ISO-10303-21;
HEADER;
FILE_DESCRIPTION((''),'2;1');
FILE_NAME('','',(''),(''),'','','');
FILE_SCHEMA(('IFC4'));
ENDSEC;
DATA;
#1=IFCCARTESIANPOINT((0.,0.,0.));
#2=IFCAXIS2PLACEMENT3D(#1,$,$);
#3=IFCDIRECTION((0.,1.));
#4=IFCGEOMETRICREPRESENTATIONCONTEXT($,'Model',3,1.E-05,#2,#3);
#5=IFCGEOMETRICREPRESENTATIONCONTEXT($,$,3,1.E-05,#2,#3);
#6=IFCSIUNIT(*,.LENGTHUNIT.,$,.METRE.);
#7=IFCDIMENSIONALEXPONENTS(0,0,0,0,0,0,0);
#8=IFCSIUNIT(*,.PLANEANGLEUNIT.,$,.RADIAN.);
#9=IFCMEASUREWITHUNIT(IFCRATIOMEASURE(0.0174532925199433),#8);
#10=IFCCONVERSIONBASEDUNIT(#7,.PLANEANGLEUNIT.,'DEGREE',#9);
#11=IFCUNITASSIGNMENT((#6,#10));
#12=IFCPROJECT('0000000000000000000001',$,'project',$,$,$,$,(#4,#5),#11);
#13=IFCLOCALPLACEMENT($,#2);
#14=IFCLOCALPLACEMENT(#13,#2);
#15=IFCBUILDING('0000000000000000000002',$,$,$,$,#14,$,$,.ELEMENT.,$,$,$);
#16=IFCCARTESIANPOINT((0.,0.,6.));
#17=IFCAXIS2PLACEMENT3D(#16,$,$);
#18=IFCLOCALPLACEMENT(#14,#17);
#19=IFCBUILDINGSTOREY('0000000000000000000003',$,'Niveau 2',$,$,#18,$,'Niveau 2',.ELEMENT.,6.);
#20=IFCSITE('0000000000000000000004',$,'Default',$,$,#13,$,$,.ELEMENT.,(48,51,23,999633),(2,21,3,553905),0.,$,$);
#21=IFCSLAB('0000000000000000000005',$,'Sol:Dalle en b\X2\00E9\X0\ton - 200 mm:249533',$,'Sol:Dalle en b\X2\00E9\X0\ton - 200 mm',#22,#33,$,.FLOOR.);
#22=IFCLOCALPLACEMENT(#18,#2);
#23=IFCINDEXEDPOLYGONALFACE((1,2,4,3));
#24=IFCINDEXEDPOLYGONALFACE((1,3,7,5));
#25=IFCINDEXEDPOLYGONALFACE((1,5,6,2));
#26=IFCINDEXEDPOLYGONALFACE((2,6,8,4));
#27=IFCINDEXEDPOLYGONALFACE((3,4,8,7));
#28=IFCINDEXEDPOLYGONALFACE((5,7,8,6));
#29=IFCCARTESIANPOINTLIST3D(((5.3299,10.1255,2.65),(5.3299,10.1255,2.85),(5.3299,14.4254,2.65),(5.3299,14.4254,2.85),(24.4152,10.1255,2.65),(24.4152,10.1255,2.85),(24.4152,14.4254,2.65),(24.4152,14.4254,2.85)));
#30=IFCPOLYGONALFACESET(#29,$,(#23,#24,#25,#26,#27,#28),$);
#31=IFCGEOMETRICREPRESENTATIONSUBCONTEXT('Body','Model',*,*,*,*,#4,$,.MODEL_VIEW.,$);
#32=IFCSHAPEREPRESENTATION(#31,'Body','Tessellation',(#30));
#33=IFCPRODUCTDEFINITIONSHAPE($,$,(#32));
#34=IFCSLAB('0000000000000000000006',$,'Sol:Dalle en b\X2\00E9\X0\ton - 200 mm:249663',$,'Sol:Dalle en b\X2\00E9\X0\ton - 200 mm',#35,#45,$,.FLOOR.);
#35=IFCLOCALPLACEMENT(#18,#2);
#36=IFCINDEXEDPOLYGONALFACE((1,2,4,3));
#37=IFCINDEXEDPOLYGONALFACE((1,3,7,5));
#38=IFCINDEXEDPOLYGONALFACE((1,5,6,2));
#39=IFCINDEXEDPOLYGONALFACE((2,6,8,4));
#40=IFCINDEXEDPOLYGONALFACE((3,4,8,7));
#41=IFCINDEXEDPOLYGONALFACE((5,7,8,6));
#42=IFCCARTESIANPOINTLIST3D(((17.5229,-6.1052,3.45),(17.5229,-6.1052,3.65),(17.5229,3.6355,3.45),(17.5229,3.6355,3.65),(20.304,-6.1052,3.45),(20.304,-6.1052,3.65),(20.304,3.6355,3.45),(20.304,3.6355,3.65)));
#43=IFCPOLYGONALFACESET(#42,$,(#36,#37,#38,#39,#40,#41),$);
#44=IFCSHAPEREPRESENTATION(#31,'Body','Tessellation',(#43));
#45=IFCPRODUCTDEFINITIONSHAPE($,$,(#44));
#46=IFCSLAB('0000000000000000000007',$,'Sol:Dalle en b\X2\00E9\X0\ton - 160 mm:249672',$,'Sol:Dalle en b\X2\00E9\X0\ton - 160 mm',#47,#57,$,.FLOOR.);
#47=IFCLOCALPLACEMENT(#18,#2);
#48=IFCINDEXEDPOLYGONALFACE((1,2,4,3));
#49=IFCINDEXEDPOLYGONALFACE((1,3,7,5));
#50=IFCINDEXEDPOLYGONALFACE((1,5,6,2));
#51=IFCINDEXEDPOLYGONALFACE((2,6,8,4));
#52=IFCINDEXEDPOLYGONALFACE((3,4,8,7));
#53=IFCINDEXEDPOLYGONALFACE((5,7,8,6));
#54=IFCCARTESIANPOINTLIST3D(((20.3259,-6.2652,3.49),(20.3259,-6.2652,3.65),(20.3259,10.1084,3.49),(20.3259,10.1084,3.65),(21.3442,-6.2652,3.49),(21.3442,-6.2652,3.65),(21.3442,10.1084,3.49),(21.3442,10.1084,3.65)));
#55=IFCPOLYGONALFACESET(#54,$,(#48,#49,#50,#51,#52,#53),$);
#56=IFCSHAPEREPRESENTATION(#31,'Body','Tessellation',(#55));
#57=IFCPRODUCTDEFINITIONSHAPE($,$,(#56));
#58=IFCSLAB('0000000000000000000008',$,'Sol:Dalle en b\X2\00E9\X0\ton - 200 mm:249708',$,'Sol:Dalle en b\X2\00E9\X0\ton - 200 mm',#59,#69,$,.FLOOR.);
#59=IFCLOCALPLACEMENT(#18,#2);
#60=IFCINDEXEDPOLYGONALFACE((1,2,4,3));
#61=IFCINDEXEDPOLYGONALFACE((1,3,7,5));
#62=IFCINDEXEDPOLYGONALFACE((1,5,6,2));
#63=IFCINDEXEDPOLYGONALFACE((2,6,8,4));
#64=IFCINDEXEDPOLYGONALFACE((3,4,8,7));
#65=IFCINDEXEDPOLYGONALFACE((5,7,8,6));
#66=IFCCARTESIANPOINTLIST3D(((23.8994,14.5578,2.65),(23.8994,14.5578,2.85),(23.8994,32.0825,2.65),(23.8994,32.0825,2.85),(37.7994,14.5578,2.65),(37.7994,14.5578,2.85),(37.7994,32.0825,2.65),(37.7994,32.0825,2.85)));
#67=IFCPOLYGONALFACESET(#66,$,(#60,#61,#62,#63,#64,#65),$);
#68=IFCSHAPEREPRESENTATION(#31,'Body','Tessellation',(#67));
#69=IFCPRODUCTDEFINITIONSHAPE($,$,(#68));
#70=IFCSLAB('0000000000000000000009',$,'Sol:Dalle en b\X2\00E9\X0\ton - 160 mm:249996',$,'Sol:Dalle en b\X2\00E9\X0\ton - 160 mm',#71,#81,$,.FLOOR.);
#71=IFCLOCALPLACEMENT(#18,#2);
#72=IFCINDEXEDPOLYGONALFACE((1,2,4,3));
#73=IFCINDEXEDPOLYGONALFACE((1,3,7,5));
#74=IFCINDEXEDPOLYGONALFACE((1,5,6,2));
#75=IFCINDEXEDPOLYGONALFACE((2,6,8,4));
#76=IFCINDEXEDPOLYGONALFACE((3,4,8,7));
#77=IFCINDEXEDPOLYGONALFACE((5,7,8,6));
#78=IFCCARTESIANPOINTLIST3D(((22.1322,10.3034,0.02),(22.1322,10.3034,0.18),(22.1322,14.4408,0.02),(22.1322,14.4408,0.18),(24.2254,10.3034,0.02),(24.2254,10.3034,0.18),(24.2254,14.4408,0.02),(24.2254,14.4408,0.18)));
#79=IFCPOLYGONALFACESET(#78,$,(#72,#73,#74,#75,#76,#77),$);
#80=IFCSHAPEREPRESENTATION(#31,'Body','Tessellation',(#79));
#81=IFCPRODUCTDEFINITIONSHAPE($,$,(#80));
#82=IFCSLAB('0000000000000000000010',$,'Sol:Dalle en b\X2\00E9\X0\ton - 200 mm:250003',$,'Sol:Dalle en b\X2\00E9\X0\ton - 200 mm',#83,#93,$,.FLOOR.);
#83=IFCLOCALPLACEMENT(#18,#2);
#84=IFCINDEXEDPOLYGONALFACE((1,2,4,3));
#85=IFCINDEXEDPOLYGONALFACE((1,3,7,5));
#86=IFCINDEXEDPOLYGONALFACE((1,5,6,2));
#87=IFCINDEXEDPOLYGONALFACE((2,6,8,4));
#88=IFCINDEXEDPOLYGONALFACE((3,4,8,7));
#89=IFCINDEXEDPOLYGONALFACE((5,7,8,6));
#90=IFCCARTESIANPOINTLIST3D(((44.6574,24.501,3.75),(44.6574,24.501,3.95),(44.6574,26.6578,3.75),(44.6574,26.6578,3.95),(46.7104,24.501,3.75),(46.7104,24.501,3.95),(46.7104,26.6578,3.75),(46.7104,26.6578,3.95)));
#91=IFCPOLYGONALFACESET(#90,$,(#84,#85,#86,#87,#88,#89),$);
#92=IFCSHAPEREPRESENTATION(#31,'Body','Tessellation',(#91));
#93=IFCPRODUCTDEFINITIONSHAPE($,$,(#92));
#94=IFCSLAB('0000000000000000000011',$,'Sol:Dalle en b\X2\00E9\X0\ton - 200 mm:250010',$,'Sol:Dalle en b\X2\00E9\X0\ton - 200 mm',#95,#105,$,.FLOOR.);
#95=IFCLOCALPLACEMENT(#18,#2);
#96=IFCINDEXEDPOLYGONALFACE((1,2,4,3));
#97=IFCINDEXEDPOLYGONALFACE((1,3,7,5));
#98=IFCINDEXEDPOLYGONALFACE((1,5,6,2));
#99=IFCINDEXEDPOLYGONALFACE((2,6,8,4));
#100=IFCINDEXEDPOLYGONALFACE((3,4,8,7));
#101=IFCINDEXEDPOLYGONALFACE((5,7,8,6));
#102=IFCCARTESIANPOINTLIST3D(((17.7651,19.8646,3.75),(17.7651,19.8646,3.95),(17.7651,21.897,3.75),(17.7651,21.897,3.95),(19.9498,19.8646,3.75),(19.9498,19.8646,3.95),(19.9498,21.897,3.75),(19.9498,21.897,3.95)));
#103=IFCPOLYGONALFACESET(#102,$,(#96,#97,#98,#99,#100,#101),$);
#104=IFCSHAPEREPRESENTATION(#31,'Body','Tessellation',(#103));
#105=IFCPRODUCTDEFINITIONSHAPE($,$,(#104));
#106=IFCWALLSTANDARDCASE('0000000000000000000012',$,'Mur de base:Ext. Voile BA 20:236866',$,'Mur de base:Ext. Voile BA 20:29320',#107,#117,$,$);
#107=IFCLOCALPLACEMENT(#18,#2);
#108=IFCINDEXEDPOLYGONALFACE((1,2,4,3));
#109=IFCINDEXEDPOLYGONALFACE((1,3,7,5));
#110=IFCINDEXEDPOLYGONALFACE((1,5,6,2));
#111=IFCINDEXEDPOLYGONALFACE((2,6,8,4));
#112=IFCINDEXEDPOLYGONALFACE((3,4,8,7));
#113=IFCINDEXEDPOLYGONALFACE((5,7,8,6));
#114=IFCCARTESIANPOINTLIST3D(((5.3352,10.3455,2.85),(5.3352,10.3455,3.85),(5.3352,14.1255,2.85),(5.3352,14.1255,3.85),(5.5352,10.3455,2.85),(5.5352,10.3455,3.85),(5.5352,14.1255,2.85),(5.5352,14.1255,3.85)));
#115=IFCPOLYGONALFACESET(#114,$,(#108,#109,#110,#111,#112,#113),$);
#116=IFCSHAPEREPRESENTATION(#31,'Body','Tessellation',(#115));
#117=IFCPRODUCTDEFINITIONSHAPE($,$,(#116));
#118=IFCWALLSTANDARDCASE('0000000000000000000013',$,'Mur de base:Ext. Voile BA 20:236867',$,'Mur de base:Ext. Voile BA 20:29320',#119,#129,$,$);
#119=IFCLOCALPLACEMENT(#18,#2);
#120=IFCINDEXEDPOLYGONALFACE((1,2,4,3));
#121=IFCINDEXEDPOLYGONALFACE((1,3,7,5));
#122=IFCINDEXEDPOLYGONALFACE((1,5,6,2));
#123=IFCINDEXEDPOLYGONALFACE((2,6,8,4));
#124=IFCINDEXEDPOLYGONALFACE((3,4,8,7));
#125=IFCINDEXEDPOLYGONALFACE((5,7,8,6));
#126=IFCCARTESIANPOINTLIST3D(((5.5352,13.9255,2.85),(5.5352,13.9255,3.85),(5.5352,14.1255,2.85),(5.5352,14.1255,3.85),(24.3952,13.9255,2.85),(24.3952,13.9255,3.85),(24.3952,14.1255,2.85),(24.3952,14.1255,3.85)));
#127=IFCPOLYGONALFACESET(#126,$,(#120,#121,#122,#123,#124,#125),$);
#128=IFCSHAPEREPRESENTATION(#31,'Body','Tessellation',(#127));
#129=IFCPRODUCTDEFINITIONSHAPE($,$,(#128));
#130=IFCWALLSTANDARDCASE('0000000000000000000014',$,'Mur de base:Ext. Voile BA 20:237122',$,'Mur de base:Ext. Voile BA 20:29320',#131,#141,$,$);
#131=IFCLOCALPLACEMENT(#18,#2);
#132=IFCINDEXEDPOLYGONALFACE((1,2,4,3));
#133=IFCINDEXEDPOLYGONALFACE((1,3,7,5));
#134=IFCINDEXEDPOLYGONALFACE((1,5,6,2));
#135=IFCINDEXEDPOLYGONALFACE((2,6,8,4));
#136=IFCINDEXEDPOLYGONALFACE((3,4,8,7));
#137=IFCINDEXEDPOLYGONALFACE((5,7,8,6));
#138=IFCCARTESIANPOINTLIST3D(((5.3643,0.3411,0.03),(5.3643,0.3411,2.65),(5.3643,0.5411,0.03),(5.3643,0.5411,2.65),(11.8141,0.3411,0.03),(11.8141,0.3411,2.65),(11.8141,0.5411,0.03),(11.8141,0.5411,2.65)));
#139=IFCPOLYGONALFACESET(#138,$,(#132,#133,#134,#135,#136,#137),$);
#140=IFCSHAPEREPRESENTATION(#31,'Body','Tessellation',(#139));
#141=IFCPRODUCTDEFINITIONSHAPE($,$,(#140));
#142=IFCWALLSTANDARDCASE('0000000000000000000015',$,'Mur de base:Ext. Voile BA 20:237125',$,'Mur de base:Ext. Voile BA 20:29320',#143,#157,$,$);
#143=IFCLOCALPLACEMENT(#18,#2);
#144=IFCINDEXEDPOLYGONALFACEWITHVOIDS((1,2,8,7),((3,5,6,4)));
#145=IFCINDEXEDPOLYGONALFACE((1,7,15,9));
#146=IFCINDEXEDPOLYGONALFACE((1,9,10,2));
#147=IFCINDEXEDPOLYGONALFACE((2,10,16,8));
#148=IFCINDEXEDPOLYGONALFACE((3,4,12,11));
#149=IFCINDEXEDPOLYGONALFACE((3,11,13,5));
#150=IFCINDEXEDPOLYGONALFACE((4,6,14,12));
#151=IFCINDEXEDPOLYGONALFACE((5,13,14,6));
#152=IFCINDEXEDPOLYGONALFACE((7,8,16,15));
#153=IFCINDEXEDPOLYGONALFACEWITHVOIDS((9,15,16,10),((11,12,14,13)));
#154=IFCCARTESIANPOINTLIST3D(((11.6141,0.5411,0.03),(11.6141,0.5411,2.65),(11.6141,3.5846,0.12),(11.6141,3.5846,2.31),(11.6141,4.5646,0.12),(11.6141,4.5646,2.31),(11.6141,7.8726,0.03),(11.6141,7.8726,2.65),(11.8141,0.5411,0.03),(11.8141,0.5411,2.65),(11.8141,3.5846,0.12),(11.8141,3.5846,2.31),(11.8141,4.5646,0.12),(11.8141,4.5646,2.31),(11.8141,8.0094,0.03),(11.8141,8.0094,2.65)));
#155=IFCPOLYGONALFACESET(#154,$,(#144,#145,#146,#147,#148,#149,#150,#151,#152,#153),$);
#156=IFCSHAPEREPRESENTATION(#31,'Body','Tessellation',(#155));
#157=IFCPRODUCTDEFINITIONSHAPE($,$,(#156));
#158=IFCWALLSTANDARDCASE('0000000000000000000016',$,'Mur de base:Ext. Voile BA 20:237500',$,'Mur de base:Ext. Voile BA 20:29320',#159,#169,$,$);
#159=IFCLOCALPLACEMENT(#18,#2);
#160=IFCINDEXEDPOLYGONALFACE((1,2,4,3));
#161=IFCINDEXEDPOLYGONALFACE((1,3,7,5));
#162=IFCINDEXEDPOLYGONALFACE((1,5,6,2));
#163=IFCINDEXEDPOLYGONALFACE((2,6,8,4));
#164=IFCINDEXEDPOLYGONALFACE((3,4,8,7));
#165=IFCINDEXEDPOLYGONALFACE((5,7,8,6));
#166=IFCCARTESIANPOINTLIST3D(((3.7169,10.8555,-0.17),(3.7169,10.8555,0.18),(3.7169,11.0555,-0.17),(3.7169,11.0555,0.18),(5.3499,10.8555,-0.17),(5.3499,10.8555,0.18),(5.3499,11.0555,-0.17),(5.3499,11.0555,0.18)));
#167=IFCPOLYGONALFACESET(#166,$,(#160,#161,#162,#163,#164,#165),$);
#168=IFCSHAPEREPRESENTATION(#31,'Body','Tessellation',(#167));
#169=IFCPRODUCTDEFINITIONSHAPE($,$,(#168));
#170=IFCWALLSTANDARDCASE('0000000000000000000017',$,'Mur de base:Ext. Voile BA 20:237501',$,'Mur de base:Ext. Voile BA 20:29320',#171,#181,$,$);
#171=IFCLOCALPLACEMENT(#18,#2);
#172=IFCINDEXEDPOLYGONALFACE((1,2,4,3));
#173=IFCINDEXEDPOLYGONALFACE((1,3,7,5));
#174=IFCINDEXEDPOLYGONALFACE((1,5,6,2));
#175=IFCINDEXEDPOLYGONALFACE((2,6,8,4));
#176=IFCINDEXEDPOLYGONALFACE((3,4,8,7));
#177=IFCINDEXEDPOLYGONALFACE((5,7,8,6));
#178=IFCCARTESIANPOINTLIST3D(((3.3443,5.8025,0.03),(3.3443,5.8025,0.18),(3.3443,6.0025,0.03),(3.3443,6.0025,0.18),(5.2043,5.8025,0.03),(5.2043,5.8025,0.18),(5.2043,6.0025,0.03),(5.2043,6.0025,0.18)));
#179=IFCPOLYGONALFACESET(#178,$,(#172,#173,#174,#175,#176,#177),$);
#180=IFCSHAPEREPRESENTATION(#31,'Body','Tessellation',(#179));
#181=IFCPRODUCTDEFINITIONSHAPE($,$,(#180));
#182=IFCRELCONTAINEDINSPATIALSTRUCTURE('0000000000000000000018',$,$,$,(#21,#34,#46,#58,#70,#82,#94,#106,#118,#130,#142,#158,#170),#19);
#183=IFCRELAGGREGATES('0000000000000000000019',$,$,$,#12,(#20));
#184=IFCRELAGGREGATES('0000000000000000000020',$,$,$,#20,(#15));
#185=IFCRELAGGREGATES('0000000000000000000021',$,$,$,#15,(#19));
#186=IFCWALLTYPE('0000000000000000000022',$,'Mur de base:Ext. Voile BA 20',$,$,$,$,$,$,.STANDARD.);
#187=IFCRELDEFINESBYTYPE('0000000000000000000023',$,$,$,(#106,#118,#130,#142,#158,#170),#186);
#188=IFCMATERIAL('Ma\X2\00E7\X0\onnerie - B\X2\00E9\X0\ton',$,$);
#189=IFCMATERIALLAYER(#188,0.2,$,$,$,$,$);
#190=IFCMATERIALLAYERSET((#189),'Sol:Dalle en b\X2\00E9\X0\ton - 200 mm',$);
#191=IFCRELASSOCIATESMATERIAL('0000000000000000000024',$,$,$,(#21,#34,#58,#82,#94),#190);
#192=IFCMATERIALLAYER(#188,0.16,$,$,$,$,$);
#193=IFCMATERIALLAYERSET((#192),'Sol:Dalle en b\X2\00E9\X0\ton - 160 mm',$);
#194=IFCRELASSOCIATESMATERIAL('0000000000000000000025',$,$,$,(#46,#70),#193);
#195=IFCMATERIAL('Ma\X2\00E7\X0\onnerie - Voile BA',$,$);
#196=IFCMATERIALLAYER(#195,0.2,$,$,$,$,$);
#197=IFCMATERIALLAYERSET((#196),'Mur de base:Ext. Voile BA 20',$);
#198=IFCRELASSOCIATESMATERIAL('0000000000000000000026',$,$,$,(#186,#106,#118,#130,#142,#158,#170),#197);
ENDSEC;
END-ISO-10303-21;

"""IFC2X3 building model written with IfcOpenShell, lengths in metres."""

from ifc_helpers import new_model, entity, si_unit, converted_unit, direction, frame, frame_2d, origin, origin_2d_with_axis, place, context, subcontext, project, spatial, polyline, rectangle, outline, extrude, material, layer, layer_set, layer_usage, type_object, element, save


model = new_model("IFC2X3")

# Units and contexts
model_context = context("Model", 3, precision=1e-05, world=origin(), true_north=direction((0.0, 1.0)))
context_of_model = context(None, 3, precision=1e-05, world=origin(), true_north=direction((0.0, 1.0)))
body_context = subcontext(model_context, "Body", "Model", "MODEL_VIEW")
ifc_project = project(units=[si_unit("LENGTHUNIT", "METRE"), converted_unit("PLANEANGLEUNIT", "DEGREE", entity("IfcRatioMeasure", 0.0174532925199433), si_unit("PLANEANGLEUNIT", "RADIAN"), dimensions=[0, 0, 0, 0, 0, 0, 0])], contexts=[model_context, context_of_model])

# Site, building, storey
site_placement = place(None, origin())
site = spatial("IfcSite", under=ifc_project, at=site_placement, Name="Default", CompositionType="ELEMENT", RefLatitude=(48, 51, 23, 999633), RefLongitude=(2, 21, 3, 553905), RefElevation=0.0)
building_placement = place(site_placement, origin())
building = spatial("IfcBuilding", under=site, at=building_placement, CompositionType="ELEMENT")
storey_placement = place(building_placement, frame((0.0, 0.0, 6.0)))
storey = spatial("IfcBuildingStorey", under=building, at=storey_placement, Name="Niveau 2", LongName="Niveau 2", CompositionType="ELEMENT", Elevation=6.0)

# Slabs
ifc_material_1 = material(Name="Maçonnerie - Béton")
ifc_layer_1 = layer(ifc_material_1, 0.2)
ifc_layer_set_1 = layer_set([ifc_layer_1], Name="Sol:Dalle en béton - 200 mm")
ifc_layer_usage_1 = layer_usage(ifc_layer_set_1, "AXIS3", "POSITIVE", 0.0)
slab_1_placement = place(storey_placement, origin())
element("IfcSlab", 1, at=slab_1_placement, inside=storey, material=ifc_layer_usage_1, Name="Sol:Dalle en béton - 200 mm:249533", ObjectType="Sol:Dalle en béton - 200 mm", PredefinedType="FLOOR", context=body_context, shape_type="SweptSolid", body=[
    extrude(rectangle(XDim=4.2999, YDim=19.0853, at=frame_2d((0.0, 0.0), x_axis=(1.0, 0.0))), frame((14.8726, 12.2754, 2.85), z_axis=(0.0, 0.0, -1.0), x_axis=(0.0, 1.0, 0.0)), (0.0, 0.0, 1.0), 0.2),
])
ifc_layer_usage_2 = layer_usage(ifc_layer_set_1, "AXIS3", "POSITIVE", 0.0)
slab_2_placement = place(storey_placement, origin())
element("IfcSlab", 2, at=slab_2_placement, inside=storey, material=ifc_layer_usage_2, Name="Sol:Dalle en béton - 200 mm:249663", ObjectType="Sol:Dalle en béton - 200 mm", PredefinedType="FLOOR", context=body_context, shape_type="SweptSolid", body=[
    extrude(rectangle(XDim=9.7406, YDim=2.781, at=frame_2d((0.0, 0.0), x_axis=(1.0, 0.0))), frame((18.9135, -1.2348, 3.65), z_axis=(0.0, 0.0, -1.0), x_axis=(0.0, 1.0, 0.0)), (0.0, 0.0, 1.0), 0.2),
])
ifc_layer_2 = layer(ifc_material_1, 0.16)
ifc_layer_set_2 = layer_set([ifc_layer_2], Name="Sol:Dalle en béton - 160 mm")
ifc_layer_usage_3 = layer_usage(ifc_layer_set_2, "AXIS3", "POSITIVE", 0.0)
slab_3_placement = place(storey_placement, origin())
element("IfcSlab", 3, at=slab_3_placement, inside=storey, material=ifc_layer_usage_3, Name="Sol:Dalle en béton - 160 mm:249672", ObjectType="Sol:Dalle en béton - 160 mm", PredefinedType="FLOOR", context=body_context, shape_type="SweptSolid", body=[
    extrude(rectangle(XDim=16.3736, YDim=1.0183, at=frame_2d((0.0, 0.0), x_axis=(1.0, 0.0))), frame((20.8351, 1.9216, 3.65), z_axis=(0.0, 0.0, -1.0), x_axis=(0.0, 1.0, 0.0)), (0.0, 0.0, 1.0), 0.16),
])

# Slab
ifc_layer_usage_4 = layer_usage(ifc_layer_set_1, "AXIS3", "POSITIVE", 0.0)
slab_4_placement = place(storey_placement, origin())
element("IfcSlab", 4, at=slab_4_placement, inside=storey, material=ifc_layer_usage_4, Name="Sol:Dalle en béton - 200 mm:249708", ObjectType="Sol:Dalle en béton - 200 mm", PredefinedType="FLOOR", context=body_context, shape_type="SweptSolid", body=[
    extrude(rectangle(XDim=17.5247, YDim=13.9, at=frame_2d((0.0, 0.0), x_axis=(1.0, 0.0))), frame((30.8494, 23.3202, 2.85), z_axis=(0.0, 0.0, -1.0), x_axis=(0.0, 1.0, 0.0)), (0.0, 0.0, 1.0), 0.2),
])

# Slabs
ifc_layer_usage_5 = layer_usage(ifc_layer_set_2, "AXIS3", "POSITIVE", 0.0)
slab_5_placement = place(storey_placement, origin())
element("IfcSlab", 5, at=slab_5_placement, inside=storey, material=ifc_layer_usage_5, Name="Sol:Dalle en béton - 160 mm:249996", ObjectType="Sol:Dalle en béton - 160 mm", PredefinedType="FLOOR", context=body_context, shape_type="SweptSolid", body=[
    extrude(rectangle(XDim=4.1374, YDim=2.0931, at=frame_2d((0.0, 0.0), x_axis=(1.0, 0.0))), frame((23.1788, 12.3721, 0.18), z_axis=(0.0, 0.0, -1.0), x_axis=(0.0, 1.0, 0.0)), (0.0, 0.0, 1.0), 0.16),
])
ifc_layer_usage_6 = layer_usage(ifc_layer_set_1, "AXIS3", "POSITIVE", 0.0)
slab_6_placement = place(storey_placement, origin())
element("IfcSlab", 6, at=slab_6_placement, inside=storey, material=ifc_layer_usage_6, Name="Sol:Dalle en béton - 200 mm:250003", ObjectType="Sol:Dalle en béton - 200 mm", PredefinedType="FLOOR", context=body_context, shape_type="SweptSolid", body=[
    extrude(rectangle(XDim=2.1568, YDim=2.053, at=frame_2d((0.0, 0.0), x_axis=(1.0, 0.0))), frame((45.6839, 25.5794, 3.95), z_axis=(0.0, 0.0, -1.0), x_axis=(0.0, 1.0, 0.0)), (0.0, 0.0, 1.0), 0.2),
])
ifc_layer_usage_7 = layer_usage(ifc_layer_set_1, "AXIS3", "POSITIVE", 0.0)
slab_7_placement = place(storey_placement, origin())
element("IfcSlab", 7, at=slab_7_placement, inside=storey, material=ifc_layer_usage_7, Name="Sol:Dalle en béton - 200 mm:250010", ObjectType="Sol:Dalle en béton - 200 mm", PredefinedType="FLOOR", context=body_context, shape_type="SweptSolid", body=[
    extrude(rectangle(XDim=2.0324, YDim=2.1848, at=frame_2d((0.0, 0.0), x_axis=(1.0, 0.0))), frame((18.8575, 20.8808, 3.95), z_axis=(0.0, 0.0, -1.0), x_axis=(0.0, 1.0, 0.0)), (0.0, 0.0, 1.0), 0.2),
])

# Walls
ifc_material_2 = material(Name="Maçonnerie - Voile BA")
ifc_layer_3 = layer(ifc_material_2, 0.2)
ifc_layer_set_3 = layer_set([ifc_layer_3], Name="Mur de base:Ext. Voile BA 20")
ifc_layer_usage_8 = layer_usage(ifc_layer_set_3, "AXIS2", "NEGATIVE", 0.1)
wall_type_1 = type_object("IfcWallType", Name="Mur de base:Ext. Voile BA 20", PredefinedType="STANDARD", material=ifc_layer_set_3)
wall_1_placement = place(storey_placement, frame((5.4352, 10.3455, 2.85), z_axis=(0.0, 0.0, 1.0), x_axis=(0.0, 1.0, 0.0)))
element("IfcWallStandardCase", 8, at=wall_1_placement, inside=storey, type_object=wall_type_1, material=ifc_layer_usage_8, Name="Mur de base:Ext. Voile BA 20:236866", ObjectType="Mur de base:Ext. Voile BA 20:29320", context=body_context, shape_type="SweptSolid", body=[
    extrude(rectangle(XDim=3.78, YDim=0.2, at=frame_2d((1.89, 0.0), x_axis=(-1.0, 0.0))), origin(), (0.0, 0.0, 1.0), 1.0),
])
ifc_layer_usage_9 = layer_usage(ifc_layer_set_3, "AXIS2", "NEGATIVE", 0.1)
wall_2_placement = place(storey_placement, frame((5.5352, 14.0255, 2.85)))
element("IfcWallStandardCase", 9, at=wall_2_placement, inside=storey, type_object=wall_type_1, material=ifc_layer_usage_9, Name="Mur de base:Ext. Voile BA 20:236867", ObjectType="Mur de base:Ext. Voile BA 20:29320", context=body_context, shape_type="SweptSolid", body=[
    extrude(rectangle(XDim=18.86, YDim=0.2, at=frame_2d((9.43, 0.0), x_axis=(-1.0, 0.0))), origin(), (0.0, 0.0, 1.0), 1.0),
])
ifc_layer_usage_10 = layer_usage(ifc_layer_set_3, "AXIS2", "NEGATIVE", 0.1)
wall_3_placement = place(storey_placement, frame((5.3643, 0.4411, 0.03)))
element("IfcWallStandardCase", 10, at=wall_3_placement, inside=storey, type_object=wall_type_1, material=ifc_layer_usage_10, Name="Mur de base:Ext. Voile BA 20:237122", ObjectType="Mur de base:Ext. Voile BA 20:29320", context=body_context, shape_type="SweptSolid", body=[
    extrude(rectangle(XDim=6.4498, YDim=0.2, at=frame_2d((3.2249, 0.0), x_axis=(-1.0, 0.0))), origin(), (0.0, 0.0, 1.0), 2.62),
])

# Wall, opening
ifc_layer_usage_11 = layer_usage(ifc_layer_set_3, "AXIS2", "NEGATIVE", 0.1)
wall_4_placement = place(storey_placement, frame((11.7141, 8.0094, 0.03), z_axis=(0.0, 0.0, 1.0), x_axis=(0.0, -1.0, 0.0)))
wall_4 = element("IfcWallStandardCase", 11, at=wall_4_placement, inside=storey, type_object=wall_type_1, material=ifc_layer_usage_11, Name="Mur de base:Ext. Voile BA 20:237125", ObjectType="Mur de base:Ext. Voile BA 20:29320", context=body_context, shape_type="SweptSolid", body=[
    extrude(outline(polyline([(7.4682, -0.1), (7.4682, 0.1), (0.0, 0.1), (0.1368, -0.1), (7.4682, -0.1)])), origin(), (0.0, 0.0, 1.0), 2.62),
])
opening_1_placement = place(wall_4_placement, origin())
element("IfcOpeningElement", 12, at=opening_1_placement, cuts=wall_4, ObjectType="Opening", context=body_context, shape_type="SweptSolid", body=[
    extrude(rectangle(XDim=2.19, YDim=0.98, at=origin_2d_with_axis()), frame((3.9347, -0.1, 1.185), z_axis=(0.0, 1.0, 0.0), x_axis=(0.0, 0.0, -1.0)), (0.0, 0.0, 1.0), 0.2),
])

# Walls
ifc_layer_usage_12 = layer_usage(ifc_layer_set_3, "AXIS2", "POSITIVE", -0.1)
wall_5_placement = place(storey_placement, frame((3.7169, 10.9555, -0.17)))
element("IfcWallStandardCase", 13, at=wall_5_placement, inside=storey, type_object=wall_type_1, material=ifc_layer_usage_12, Name="Mur de base:Ext. Voile BA 20:237500", ObjectType="Mur de base:Ext. Voile BA 20:29320", context=body_context, shape_type="SweptSolid", body=[
    extrude(rectangle(XDim=1.633, YDim=0.2, at=frame_2d((0.8165, 0.0), x_axis=(-1.0, 0.0))), origin(), (0.0, 0.0, 1.0), 0.35),
])
ifc_layer_usage_13 = layer_usage(ifc_layer_set_3, "AXIS2", "NEGATIVE", 0.1)
wall_6_placement = place(storey_placement, frame((5.2043, 5.9025, 0.03), z_axis=(0.0, 0.0, 1.0), x_axis=(-1.0, 0.0, 0.0)))
element("IfcWallStandardCase", 14, at=wall_6_placement, inside=storey, type_object=wall_type_1, material=ifc_layer_usage_13, Name="Mur de base:Ext. Voile BA 20:237501", ObjectType="Mur de base:Ext. Voile BA 20:29320", context=body_context, shape_type="SweptSolid", body=[
    extrude(rectangle(XDim=1.86, YDim=0.2, at=frame_2d((0.93, 0.0), x_axis=(-1.0, 0.0))), origin(), (0.0, 0.0, 1.0), 0.15),
])

save(model, "model.ifc")
